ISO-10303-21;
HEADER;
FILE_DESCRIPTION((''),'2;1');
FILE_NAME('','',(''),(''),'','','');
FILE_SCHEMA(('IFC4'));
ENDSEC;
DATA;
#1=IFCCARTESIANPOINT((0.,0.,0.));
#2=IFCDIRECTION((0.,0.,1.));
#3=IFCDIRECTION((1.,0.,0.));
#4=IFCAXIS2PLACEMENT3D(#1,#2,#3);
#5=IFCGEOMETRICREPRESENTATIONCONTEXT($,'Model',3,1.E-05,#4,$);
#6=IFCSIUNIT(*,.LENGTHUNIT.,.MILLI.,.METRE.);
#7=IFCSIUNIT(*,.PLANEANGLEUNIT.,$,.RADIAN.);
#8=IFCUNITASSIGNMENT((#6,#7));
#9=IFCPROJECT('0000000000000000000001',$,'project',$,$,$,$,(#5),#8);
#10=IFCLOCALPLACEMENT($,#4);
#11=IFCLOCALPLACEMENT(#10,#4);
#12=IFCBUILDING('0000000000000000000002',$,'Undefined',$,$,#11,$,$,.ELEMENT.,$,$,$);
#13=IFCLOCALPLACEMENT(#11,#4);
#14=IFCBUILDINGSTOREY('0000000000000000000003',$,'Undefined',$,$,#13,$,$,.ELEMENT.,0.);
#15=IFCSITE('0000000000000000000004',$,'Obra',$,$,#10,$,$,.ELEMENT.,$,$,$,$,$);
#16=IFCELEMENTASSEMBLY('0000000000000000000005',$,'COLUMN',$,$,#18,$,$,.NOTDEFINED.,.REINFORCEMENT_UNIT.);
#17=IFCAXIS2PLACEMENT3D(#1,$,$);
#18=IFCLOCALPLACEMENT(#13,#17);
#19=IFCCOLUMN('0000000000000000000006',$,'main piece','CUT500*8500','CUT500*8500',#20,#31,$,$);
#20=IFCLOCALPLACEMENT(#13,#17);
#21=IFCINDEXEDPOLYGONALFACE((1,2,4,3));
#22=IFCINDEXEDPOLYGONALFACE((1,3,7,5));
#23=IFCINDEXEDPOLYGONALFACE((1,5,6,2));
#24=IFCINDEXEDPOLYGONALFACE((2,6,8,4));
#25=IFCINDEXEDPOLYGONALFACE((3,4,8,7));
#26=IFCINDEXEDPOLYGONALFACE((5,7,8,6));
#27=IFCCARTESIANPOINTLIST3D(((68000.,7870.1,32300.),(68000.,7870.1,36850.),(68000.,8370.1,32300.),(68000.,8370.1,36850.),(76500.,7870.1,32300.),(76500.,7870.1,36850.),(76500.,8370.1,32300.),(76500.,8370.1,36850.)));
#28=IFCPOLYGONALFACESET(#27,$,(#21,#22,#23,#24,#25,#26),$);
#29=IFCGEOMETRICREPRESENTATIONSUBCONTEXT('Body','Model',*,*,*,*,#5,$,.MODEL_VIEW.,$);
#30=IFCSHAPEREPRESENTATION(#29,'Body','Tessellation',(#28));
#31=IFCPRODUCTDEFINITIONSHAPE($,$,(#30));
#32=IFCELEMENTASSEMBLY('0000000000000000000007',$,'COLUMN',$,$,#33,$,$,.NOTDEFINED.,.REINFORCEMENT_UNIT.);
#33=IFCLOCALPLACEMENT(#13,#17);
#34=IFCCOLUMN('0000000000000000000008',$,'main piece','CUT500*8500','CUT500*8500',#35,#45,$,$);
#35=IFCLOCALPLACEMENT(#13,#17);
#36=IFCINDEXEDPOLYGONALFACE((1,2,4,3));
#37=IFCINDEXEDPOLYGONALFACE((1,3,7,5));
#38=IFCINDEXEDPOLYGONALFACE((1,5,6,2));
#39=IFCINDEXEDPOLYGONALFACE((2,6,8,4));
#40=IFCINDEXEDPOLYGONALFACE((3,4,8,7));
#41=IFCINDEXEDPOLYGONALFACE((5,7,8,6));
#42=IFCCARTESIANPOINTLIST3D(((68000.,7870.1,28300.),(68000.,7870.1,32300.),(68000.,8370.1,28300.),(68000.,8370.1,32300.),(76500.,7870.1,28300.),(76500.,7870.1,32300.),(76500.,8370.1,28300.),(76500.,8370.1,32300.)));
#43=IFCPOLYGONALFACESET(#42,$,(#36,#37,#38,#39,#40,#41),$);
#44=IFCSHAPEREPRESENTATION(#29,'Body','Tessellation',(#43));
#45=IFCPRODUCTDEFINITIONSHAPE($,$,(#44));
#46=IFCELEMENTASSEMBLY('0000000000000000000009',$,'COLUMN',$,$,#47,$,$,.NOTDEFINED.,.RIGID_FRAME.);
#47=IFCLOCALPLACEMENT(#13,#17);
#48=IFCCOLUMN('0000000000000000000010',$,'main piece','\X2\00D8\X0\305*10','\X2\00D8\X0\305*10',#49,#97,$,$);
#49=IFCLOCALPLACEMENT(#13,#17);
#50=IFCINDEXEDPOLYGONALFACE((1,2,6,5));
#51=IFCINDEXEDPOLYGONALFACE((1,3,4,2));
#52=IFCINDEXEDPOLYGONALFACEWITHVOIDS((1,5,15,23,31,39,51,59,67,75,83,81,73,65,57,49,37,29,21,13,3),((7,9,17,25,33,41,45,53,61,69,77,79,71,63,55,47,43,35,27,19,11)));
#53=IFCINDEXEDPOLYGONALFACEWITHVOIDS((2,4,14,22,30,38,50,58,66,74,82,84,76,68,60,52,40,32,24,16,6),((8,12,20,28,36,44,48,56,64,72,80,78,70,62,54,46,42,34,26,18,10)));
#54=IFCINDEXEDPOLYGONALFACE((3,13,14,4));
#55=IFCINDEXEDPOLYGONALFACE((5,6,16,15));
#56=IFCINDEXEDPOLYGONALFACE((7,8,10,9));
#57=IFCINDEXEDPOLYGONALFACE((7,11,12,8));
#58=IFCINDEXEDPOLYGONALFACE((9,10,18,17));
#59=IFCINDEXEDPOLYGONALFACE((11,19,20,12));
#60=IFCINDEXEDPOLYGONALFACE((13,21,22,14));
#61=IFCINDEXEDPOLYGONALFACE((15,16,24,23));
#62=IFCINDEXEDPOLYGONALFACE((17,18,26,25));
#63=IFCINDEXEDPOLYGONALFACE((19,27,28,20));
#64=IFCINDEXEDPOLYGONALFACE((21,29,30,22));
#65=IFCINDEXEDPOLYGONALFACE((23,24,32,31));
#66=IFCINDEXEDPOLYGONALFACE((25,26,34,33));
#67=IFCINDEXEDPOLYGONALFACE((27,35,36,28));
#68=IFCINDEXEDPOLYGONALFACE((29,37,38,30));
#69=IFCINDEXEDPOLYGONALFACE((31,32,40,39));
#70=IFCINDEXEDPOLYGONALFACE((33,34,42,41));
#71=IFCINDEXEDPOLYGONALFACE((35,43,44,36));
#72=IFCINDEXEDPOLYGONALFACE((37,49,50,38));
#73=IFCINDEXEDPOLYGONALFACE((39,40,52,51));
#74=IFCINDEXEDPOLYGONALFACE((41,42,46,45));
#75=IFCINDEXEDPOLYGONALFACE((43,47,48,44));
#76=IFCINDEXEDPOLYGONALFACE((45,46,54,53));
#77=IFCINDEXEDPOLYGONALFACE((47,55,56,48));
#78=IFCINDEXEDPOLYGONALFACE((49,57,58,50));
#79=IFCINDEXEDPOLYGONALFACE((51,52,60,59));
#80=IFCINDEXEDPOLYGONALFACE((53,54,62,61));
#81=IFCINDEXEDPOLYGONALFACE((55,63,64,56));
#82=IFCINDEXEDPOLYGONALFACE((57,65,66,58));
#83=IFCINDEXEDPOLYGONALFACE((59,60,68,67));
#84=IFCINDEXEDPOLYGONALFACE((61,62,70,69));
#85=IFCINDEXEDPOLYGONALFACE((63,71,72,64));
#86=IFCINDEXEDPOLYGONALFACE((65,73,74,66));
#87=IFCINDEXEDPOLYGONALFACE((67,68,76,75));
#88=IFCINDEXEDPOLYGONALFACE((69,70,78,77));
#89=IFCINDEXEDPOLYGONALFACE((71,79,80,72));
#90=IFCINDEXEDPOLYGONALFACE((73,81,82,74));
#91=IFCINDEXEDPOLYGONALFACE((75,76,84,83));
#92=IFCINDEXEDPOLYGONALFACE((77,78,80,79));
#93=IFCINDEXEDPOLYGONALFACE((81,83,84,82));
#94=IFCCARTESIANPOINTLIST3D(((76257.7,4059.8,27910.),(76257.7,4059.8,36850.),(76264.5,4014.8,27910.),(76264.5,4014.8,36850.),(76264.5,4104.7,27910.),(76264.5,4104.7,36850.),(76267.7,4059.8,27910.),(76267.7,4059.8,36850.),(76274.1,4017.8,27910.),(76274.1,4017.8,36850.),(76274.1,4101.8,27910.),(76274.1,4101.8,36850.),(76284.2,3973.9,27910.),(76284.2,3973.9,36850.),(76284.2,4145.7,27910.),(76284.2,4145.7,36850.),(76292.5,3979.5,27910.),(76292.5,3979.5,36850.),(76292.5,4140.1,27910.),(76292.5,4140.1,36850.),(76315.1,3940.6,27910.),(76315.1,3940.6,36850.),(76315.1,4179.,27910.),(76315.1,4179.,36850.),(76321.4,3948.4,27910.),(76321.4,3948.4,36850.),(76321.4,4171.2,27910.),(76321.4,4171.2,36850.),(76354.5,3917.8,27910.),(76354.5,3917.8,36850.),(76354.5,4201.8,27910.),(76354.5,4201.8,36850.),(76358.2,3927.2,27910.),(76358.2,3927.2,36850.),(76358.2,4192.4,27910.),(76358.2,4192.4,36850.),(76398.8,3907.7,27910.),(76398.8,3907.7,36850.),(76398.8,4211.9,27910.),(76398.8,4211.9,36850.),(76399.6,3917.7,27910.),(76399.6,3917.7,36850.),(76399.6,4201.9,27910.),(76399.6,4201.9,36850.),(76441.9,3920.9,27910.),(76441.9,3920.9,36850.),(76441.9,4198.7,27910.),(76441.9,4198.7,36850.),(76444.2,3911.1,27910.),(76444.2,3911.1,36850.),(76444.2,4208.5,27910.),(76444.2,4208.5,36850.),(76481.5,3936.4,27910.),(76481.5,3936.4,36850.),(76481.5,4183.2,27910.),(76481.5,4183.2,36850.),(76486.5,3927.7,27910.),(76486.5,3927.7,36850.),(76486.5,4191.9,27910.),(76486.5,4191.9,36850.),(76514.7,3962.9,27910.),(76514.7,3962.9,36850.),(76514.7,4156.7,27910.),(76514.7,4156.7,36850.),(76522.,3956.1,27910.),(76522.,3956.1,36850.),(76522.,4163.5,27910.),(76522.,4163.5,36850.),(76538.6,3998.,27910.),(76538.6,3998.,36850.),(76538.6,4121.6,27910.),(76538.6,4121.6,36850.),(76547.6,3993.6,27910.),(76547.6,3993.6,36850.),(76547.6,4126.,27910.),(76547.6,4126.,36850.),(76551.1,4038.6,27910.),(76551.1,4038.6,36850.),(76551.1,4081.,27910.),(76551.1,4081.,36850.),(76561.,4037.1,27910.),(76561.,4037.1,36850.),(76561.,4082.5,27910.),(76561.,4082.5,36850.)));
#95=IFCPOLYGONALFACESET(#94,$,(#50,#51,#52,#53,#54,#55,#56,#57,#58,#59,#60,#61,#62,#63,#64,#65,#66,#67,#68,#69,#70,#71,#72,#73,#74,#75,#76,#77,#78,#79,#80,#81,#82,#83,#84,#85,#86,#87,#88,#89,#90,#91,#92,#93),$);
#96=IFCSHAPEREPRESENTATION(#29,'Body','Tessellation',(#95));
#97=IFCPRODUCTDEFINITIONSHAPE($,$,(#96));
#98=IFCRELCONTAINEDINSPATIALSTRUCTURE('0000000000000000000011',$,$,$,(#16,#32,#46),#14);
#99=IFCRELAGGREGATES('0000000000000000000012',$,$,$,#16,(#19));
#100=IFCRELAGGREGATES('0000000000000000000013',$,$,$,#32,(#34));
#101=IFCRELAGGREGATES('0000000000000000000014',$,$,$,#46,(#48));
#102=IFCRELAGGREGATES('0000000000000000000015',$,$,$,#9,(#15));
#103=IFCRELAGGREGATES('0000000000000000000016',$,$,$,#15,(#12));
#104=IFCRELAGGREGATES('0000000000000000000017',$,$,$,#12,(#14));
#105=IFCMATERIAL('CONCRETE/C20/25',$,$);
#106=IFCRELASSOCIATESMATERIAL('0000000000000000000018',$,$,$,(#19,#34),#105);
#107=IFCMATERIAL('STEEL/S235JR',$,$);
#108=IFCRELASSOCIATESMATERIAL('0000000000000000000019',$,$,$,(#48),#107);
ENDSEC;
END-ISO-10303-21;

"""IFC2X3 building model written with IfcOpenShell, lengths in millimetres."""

from ifc_helpers import new_model, si_unit, frame, origin_with_axes, origin_2d_with_axis, place, context, subcontext, project, spatial, rectangle, hollow_circle, extrude, material, element, aggregate, save


model = new_model("IFC2X3")

# Units and contexts
model_context = context("Model", 3, precision=1e-05, world=origin_with_axes())
body_context = subcontext(model_context, "Body", "Model", "MODEL_VIEW")
ifc_project = project(units=[si_unit("LENGTHUNIT", "METRE", prefix="MILLI"), si_unit("PLANEANGLEUNIT", "RADIAN")], contexts=[model_context])

# Site, building, storey
site_placement = place(None, origin_with_axes())
site = spatial("IfcSite", under=ifc_project, at=site_placement, Name="Obra", CompositionType="ELEMENT")
building_placement = place(site_placement, origin_with_axes())
building = spatial("IfcBuilding", under=site, at=building_placement, Name="Undefined", CompositionType="ELEMENT")
storey_placement = place(building_placement, origin_with_axes())
storey = spatial("IfcBuildingStorey", under=building, at=storey_placement, Name="Undefined", CompositionType="ELEMENT", Elevation=0.0)

# Element assemblies, columns
assembly_1_placement = place(storey_placement, origin_with_axes())
assembly_1 = element("IfcElementAssembly", 1, at=assembly_1_placement, inside=storey, Name="COLUMN", AssemblyPlace="NOTDEFINED", PredefinedType="REINFORCEMENT_UNIT")
ifc_material_1 = material(Name="CONCRETE/C20/25")
column_1_placement = place(assembly_1_placement, frame((72250.0, 8120.1, 32300.0), z_axis=(0.0, 0.0, 1.0), x_axis=(-1.0, 0.0, 0.0)))
column_1 = element("IfcColumn", 2, at=column_1_placement, material=ifc_material_1, Name="main piece", Description="CUT500*8500", ObjectType="CUT500*8500", context=body_context, shape_type="SweptSolid", body=[
    extrude(rectangle(XDim=500.0, YDim=8500.0, at=origin_2d_with_axis()), frame((0.0, 0.0, 4550.0), z_axis=(0.0, 0.0, -1.0), x_axis=(0.0, 1.0, 0.0)), (0.0, 0.0, 1.0), 4550.0),
])
aggregate(assembly_1, [column_1])
assembly_2_placement = place(storey_placement, origin_with_axes())
assembly_2 = element("IfcElementAssembly", 3, at=assembly_2_placement, inside=storey, Name="COLUMN", AssemblyPlace="NOTDEFINED", PredefinedType="REINFORCEMENT_UNIT")
column_2_placement = place(assembly_2_placement, frame((72250.0, 8120.1, 28300.0), z_axis=(0.0, 0.0, 1.0), x_axis=(-1.0, 0.0, 0.0)))
column_2 = element("IfcColumn", 4, at=column_2_placement, material=ifc_material_1, Name="main piece", Description="CUT500*8500", ObjectType="CUT500*8500", context=body_context, shape_type="SweptSolid", body=[
    extrude(rectangle(XDim=500.0, YDim=8500.0, at=origin_2d_with_axis()), frame((0.0, 0.0, 4000.0), z_axis=(0.0, 0.0, -1.0), x_axis=(0.0, 1.0, 0.0)), (0.0, 0.0, 1.0), 4000.0),
])
aggregate(assembly_2, [column_2])
assembly_3_placement = place(storey_placement, origin_with_axes())
assembly_3 = element("IfcElementAssembly", 5, at=assembly_3_placement, inside=storey, Name="COLUMN", AssemblyPlace="NOTDEFINED", PredefinedType="RIGID_FRAME")
ifc_material_2 = material(Name="STEEL/S235JR")
column_3_placement = place(assembly_3_placement, frame((76410.2, 4059.8, 27910.0), z_axis=(0.0, 0.0, 1.0), x_axis=(0.0, 1.0, 0.0)))
column_3 = element("IfcColumn", 6, at=column_3_placement, material=ifc_material_2, Name="main piece", Description="Ø305*10", ObjectType="Ø305*10", context=body_context, shape_type="SweptSolid", body=[
    extrude(hollow_circle(Radius=152.5, WallThickness=10.0, at=origin_2d_with_axis()), frame((0.0, 0.0, 8940.0), z_axis=(0.0, 0.0, -1.0), x_axis=(0.0, 1.0, 0.0)), (0.0, 0.0, 1.0), 8940.0),
])

aggregate(assembly_3, [column_3])

save(model, "model.ifc")
